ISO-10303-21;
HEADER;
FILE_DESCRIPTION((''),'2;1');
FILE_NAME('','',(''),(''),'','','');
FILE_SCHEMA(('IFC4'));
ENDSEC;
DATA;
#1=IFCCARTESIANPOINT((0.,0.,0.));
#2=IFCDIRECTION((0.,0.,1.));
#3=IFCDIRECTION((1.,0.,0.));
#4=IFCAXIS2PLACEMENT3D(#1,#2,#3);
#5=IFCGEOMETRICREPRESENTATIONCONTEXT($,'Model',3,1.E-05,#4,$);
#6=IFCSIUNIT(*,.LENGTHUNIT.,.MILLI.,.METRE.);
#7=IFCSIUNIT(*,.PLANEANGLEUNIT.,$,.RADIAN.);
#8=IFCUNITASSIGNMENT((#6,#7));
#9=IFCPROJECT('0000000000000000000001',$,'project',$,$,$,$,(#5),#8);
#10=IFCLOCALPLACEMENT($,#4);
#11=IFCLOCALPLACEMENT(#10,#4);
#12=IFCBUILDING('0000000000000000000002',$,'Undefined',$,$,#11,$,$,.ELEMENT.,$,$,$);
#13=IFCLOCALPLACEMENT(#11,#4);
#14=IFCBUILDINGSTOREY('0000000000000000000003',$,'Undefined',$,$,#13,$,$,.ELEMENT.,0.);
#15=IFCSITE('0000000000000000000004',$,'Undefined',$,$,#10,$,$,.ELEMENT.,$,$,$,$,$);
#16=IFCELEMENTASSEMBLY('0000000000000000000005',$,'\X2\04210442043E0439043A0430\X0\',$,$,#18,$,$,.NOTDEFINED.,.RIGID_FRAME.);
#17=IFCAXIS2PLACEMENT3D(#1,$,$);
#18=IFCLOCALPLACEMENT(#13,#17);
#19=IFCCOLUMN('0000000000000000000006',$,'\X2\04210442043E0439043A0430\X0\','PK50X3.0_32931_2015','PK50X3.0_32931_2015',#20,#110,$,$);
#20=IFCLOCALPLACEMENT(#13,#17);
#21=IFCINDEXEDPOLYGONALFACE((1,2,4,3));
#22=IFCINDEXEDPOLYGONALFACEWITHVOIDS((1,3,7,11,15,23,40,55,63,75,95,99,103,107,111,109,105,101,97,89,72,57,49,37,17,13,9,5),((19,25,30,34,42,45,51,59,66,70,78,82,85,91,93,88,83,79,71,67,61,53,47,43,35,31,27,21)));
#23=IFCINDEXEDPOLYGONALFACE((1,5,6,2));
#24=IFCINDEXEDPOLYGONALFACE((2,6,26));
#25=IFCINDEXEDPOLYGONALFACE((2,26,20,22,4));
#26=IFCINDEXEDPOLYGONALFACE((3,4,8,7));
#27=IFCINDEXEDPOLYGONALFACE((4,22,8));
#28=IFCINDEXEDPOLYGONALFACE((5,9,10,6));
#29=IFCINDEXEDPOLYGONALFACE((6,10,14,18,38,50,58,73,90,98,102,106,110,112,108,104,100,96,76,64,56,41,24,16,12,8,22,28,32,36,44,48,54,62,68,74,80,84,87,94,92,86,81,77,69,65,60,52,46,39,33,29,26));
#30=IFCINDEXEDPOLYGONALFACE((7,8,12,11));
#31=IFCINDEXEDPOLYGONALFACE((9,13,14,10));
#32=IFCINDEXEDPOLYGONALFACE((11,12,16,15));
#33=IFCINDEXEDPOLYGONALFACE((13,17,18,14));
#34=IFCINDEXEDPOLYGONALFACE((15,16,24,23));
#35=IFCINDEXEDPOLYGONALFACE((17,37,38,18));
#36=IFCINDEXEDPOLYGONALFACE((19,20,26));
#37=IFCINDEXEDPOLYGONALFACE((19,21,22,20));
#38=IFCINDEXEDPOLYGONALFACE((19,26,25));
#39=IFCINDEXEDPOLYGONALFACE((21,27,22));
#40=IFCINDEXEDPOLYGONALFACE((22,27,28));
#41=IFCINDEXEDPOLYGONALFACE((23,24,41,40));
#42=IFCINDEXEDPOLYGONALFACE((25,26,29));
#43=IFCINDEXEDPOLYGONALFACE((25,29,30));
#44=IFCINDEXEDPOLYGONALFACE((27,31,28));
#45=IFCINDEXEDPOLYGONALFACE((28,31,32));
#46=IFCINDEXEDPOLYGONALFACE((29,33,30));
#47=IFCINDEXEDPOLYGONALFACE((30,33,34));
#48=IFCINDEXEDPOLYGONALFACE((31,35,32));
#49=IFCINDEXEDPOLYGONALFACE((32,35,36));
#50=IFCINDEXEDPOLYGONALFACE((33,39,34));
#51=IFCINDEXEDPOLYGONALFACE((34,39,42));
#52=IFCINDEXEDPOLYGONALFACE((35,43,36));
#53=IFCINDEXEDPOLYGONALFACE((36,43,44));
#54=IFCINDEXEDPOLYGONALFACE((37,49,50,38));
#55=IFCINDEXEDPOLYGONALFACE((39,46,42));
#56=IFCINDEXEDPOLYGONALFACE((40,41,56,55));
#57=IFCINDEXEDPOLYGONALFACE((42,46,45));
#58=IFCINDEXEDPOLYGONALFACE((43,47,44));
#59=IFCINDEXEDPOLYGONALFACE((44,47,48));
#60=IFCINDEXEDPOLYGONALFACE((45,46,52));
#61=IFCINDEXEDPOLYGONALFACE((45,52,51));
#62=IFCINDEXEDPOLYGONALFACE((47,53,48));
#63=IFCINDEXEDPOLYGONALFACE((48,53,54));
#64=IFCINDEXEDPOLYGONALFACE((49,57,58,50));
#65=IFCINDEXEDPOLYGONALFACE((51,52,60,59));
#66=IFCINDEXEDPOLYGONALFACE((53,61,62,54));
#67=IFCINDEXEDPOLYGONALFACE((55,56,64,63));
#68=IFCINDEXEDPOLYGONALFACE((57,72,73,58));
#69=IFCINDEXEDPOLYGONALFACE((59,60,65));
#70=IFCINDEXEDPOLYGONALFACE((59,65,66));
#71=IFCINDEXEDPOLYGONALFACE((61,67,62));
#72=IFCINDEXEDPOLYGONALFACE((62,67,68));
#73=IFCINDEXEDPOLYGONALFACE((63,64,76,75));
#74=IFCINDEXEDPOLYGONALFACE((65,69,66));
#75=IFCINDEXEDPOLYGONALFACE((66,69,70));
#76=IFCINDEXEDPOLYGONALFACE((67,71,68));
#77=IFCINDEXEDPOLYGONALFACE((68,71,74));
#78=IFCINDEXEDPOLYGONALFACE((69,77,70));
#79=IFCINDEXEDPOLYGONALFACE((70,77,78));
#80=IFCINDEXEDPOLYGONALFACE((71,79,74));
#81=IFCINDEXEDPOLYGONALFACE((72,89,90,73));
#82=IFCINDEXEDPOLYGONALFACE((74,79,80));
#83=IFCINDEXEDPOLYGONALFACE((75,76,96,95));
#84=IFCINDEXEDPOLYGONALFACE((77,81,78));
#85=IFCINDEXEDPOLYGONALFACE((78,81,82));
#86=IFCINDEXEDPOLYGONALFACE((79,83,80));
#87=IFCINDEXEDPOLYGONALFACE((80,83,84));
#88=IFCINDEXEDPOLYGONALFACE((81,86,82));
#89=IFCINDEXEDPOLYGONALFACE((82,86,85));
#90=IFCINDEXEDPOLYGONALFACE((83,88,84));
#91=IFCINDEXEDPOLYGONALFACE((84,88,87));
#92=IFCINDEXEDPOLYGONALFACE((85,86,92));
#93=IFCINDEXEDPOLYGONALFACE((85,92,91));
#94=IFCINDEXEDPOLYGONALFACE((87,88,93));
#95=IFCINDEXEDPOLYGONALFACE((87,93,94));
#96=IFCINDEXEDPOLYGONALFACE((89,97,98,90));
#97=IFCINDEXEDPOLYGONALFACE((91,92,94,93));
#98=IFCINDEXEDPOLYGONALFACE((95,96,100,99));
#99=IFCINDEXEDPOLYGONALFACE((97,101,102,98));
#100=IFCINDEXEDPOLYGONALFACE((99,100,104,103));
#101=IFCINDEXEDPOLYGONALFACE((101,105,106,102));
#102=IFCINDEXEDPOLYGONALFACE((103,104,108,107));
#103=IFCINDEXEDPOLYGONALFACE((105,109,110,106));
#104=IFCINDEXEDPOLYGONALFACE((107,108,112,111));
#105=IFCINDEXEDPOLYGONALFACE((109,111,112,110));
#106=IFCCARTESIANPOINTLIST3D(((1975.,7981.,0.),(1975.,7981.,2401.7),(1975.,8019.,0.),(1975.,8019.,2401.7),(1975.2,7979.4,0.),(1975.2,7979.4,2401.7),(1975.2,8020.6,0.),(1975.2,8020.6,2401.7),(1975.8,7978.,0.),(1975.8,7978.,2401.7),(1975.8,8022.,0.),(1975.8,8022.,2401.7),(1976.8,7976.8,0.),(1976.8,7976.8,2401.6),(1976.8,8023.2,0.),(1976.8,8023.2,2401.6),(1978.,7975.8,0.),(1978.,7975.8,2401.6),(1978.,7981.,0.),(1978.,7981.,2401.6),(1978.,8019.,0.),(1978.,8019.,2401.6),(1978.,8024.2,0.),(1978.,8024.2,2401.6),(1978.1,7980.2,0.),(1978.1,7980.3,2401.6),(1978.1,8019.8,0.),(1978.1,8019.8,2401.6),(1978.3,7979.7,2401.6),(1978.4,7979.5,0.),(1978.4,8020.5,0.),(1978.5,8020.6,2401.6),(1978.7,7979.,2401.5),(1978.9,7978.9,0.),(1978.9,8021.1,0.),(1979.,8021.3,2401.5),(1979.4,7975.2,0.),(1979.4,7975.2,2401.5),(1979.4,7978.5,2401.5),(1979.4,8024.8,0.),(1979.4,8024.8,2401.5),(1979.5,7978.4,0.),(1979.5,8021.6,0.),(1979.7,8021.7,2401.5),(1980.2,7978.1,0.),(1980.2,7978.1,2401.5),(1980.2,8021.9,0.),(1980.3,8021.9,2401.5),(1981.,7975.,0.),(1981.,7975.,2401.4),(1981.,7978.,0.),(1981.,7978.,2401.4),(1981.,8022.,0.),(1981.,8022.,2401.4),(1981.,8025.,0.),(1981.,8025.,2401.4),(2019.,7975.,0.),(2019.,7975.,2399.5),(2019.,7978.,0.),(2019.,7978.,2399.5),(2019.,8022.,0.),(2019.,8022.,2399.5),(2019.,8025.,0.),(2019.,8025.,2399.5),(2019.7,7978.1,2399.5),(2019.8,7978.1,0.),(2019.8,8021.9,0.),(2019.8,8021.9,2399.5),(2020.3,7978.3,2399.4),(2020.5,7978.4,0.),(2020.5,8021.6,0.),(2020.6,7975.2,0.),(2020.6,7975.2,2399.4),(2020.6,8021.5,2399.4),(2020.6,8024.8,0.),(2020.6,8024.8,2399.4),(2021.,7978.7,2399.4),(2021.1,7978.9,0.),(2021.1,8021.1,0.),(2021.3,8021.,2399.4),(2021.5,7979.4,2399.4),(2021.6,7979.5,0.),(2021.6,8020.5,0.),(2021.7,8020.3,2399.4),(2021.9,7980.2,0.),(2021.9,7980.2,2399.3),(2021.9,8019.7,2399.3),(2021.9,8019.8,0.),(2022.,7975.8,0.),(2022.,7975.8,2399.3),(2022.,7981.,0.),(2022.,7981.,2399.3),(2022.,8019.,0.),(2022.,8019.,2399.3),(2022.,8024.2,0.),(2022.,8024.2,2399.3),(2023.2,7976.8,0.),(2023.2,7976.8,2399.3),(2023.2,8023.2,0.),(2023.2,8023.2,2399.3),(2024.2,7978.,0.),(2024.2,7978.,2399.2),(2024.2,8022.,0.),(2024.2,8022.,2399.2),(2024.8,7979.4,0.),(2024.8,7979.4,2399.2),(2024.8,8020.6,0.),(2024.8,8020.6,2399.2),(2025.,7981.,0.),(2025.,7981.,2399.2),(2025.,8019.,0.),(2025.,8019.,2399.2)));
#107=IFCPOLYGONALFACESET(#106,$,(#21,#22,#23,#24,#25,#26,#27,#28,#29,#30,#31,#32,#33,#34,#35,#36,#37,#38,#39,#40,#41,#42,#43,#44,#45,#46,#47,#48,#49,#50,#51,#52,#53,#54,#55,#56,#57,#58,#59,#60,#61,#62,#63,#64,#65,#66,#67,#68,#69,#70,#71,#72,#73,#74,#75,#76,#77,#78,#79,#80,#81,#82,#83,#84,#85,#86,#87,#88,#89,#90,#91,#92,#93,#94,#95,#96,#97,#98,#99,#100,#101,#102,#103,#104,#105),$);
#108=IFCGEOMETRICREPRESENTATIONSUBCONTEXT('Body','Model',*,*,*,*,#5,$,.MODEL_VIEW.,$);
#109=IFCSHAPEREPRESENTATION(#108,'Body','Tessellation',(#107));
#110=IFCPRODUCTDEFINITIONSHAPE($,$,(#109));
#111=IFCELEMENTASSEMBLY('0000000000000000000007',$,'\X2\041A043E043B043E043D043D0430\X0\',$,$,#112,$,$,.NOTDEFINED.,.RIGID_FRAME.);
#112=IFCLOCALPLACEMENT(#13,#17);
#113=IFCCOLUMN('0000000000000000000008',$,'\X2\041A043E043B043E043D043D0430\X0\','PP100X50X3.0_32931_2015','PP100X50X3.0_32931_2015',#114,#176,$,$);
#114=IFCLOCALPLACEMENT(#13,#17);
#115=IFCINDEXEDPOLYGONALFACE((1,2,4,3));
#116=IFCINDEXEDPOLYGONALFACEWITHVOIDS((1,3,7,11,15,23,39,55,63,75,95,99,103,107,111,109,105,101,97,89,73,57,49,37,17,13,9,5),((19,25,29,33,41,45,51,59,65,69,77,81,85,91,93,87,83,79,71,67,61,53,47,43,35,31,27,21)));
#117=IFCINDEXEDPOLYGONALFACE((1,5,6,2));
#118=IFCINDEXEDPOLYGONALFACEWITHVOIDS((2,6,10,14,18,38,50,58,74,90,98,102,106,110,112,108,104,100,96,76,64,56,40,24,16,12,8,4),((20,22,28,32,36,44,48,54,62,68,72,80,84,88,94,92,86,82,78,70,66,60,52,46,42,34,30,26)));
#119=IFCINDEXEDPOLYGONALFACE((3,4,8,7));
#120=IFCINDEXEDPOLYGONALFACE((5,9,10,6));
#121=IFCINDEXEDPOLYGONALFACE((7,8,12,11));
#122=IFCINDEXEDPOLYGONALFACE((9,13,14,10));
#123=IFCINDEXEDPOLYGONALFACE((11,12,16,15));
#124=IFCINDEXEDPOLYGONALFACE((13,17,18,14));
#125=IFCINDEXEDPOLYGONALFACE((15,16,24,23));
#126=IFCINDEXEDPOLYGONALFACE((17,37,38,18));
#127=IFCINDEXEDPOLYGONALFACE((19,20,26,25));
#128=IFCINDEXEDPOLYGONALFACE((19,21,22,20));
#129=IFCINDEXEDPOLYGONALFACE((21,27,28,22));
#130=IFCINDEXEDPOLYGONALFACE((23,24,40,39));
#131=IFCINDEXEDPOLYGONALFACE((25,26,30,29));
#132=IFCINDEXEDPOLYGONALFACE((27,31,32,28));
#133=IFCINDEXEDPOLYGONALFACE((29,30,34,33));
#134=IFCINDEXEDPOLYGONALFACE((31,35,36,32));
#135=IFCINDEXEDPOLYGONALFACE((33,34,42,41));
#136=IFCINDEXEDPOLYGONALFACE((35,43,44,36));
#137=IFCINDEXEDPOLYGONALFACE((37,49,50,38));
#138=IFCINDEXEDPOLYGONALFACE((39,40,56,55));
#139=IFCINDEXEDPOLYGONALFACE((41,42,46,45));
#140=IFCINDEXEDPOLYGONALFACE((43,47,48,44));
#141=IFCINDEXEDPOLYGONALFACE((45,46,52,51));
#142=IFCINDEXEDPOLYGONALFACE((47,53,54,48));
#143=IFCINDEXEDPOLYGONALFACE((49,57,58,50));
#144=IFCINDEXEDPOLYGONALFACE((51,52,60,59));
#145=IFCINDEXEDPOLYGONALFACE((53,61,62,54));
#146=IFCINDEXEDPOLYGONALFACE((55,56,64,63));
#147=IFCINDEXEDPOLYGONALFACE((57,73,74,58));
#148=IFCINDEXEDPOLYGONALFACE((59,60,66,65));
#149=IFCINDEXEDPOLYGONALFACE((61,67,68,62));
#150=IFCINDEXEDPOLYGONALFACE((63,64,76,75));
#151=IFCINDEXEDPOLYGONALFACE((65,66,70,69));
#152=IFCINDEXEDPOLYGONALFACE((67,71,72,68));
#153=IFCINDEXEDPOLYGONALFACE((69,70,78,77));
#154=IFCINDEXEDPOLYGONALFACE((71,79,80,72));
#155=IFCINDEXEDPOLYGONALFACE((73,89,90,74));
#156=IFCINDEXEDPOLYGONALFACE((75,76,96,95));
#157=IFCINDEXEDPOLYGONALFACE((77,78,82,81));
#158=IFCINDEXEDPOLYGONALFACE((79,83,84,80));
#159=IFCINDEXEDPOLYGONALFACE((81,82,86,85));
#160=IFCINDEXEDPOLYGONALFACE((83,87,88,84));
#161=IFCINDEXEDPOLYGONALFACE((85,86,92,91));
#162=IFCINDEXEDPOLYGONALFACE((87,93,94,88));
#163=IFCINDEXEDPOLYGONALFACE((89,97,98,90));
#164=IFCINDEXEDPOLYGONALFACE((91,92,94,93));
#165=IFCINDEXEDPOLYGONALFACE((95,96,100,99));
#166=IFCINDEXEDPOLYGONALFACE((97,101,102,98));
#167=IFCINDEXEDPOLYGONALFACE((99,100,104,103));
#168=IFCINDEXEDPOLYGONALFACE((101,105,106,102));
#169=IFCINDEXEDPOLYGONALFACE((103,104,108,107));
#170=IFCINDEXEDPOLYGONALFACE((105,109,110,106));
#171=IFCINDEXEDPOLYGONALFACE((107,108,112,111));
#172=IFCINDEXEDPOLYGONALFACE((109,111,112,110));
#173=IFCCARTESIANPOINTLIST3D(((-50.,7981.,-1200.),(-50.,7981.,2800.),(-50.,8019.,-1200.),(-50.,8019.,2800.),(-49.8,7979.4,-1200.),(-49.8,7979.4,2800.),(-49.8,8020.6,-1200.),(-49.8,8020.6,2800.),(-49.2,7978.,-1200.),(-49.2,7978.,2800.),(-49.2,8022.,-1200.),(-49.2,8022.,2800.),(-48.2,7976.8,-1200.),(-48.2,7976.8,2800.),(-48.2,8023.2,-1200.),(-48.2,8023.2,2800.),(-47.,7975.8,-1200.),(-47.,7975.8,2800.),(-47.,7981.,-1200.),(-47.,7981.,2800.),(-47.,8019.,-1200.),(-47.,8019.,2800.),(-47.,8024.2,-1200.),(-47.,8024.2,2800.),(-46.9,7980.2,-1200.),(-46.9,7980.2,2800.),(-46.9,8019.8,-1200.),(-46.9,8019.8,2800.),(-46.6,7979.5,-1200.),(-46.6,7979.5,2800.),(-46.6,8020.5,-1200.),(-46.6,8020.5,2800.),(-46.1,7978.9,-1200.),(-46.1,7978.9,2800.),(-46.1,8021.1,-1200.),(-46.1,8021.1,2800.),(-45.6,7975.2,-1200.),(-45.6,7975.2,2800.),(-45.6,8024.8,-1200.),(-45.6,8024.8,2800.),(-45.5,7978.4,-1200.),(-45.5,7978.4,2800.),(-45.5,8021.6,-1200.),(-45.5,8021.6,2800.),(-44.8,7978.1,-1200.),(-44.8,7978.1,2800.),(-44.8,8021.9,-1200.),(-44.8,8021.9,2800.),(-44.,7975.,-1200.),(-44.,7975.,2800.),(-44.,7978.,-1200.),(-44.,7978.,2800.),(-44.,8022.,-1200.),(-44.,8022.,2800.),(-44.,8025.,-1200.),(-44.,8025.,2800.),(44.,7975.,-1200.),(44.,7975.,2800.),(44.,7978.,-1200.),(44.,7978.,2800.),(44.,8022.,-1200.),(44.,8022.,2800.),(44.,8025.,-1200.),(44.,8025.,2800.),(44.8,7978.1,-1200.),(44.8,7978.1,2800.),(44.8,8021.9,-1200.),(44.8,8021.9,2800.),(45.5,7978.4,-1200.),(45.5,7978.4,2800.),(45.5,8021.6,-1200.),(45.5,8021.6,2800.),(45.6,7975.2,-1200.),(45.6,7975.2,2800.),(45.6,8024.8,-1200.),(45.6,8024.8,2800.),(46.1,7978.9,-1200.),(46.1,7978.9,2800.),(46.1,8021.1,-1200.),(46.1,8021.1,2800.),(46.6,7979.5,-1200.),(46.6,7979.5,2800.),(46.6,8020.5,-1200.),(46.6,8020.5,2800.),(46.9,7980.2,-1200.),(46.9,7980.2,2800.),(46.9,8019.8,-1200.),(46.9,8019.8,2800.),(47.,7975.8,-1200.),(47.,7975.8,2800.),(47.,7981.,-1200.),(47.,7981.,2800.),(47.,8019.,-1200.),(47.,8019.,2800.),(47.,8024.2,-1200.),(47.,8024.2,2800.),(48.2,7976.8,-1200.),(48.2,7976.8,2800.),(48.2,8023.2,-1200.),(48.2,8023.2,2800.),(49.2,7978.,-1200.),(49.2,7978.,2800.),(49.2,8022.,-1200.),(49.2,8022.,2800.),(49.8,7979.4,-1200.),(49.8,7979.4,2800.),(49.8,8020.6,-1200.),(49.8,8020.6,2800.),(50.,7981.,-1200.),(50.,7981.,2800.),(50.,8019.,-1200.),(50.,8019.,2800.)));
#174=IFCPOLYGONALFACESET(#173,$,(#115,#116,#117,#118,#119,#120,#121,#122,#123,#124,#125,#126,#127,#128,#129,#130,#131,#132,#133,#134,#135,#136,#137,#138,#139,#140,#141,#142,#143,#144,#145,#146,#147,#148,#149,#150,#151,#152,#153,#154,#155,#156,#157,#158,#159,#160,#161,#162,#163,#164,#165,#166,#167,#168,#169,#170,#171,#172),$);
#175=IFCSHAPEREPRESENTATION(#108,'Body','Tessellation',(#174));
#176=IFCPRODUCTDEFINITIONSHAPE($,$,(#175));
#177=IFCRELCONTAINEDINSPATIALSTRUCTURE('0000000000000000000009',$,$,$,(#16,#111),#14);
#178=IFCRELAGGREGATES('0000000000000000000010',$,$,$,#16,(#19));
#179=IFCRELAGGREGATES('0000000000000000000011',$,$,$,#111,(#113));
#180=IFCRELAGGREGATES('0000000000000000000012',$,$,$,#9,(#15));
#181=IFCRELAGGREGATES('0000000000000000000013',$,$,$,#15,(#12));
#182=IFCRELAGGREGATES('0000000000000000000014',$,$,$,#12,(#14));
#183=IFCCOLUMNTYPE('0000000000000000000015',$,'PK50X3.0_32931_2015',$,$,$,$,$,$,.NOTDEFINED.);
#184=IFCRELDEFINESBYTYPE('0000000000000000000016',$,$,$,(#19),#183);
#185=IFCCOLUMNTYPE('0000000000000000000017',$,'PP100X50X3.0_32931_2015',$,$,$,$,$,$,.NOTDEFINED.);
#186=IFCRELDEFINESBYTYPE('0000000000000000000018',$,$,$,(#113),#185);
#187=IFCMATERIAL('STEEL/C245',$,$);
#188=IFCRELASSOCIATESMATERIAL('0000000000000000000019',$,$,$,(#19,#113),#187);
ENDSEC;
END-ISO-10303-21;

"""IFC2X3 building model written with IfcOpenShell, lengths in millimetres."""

from ifc_helpers import new_model, si_unit, frame, origin_with_axes, origin_2d_with_axis, place, context, subcontext, project, spatial, hollow_rectangle, extrude, clip, halfspace, material, type_object, element, aggregate, save


model = new_model("IFC2X3")

# Units and contexts
model_context = context("Model", 3, precision=1e-05, world=origin_with_axes())
body_context = subcontext(model_context, "Body", "Model", "MODEL_VIEW")
ifc_project = project(units=[si_unit("LENGTHUNIT", "METRE", prefix="MILLI"), si_unit("PLANEANGLEUNIT", "RADIAN")], contexts=[model_context])

# Site, building, storey
site_placement = place(None, origin_with_axes())
site = spatial("IfcSite", under=ifc_project, at=site_placement, Name="Undefined", CompositionType="ELEMENT")
building_placement = place(site_placement, origin_with_axes())
building = spatial("IfcBuilding", under=site, at=building_placement, Name="Undefined", CompositionType="ELEMENT")
storey_placement = place(building_placement, origin_with_axes())
storey = spatial("IfcBuildingStorey", under=building, at=storey_placement, Name="Undefined", CompositionType="ELEMENT", Elevation=0.0)

# Element assemblies, columns
ifc_material_1 = material(Name="STEEL/C245")
column_type_1 = type_object("IfcColumnType", Name="PK50X3.0_32931_2015", PredefinedType="NOTDEFINED")
assembly_1_placement = place(storey_placement, origin_with_axes())
assembly_1 = element("IfcElementAssembly", 1, at=assembly_1_placement, inside=storey, Name="Стойка", AssemblyPlace="NOTDEFINED", PredefinedType="RIGID_FRAME")
column_1_placement = place(assembly_1_placement, frame((2000.0, 8000.0, 0.0), z_axis=(0.0, 0.0, 1.0), x_axis=(0.0, 1.0, 0.0)))
column_1 = element("IfcColumn", 2, at=column_1_placement, type_object=column_type_1, material=ifc_material_1, Name="Стойка", Description="PK50X3.0_32931_2015", ObjectType="PK50X3.0_32931_2015", context=body_context, shape_type="Clipping", body=[
    clip(extrude(hollow_rectangle(XDim=50.0, YDim=50.0, WallThickness=3.0, InnerFilletRadius=3.0, OuterFilletRadius=6.0, at=origin_2d_with_axis()), frame((0.0, 0.0, 2401.7), z_axis=(0.0, 0.0, -1.0), x_axis=(0.0, 1.0, 0.0)), (0.0, 0.0, 1.0), 2401.7), halfspace(frame((0.0, -2147.1, 2291.3), z_axis=(0.0, 0.050782, -0.99871), x_axis=(-1.0, 0.0, 0.0)), True)),
])
aggregate(assembly_1, [column_1])
assembly_2_placement = place(storey_placement, origin_with_axes())
assembly_2 = element("IfcElementAssembly", 3, at=assembly_2_placement, inside=storey, Name="Колонна", AssemblyPlace="NOTDEFINED", PredefinedType="RIGID_FRAME")
column_type_2 = type_object("IfcColumnType", Name="PP100X50X3.0_32931_2015", PredefinedType="NOTDEFINED")
column_2_placement = place(assembly_2_placement, frame((0.0, 8000.0, -1200.0), z_axis=(0.0, 0.0, 1.0), x_axis=(-1.0, 0.0, 0.0)))
column_2 = element("IfcColumn", 4, at=column_2_placement, type_object=column_type_2, material=ifc_material_1, Name="Колонна", Description="PP100X50X3.0_32931_2015", ObjectType="PP100X50X3.0_32931_2015", context=body_context, shape_type="SweptSolid", body=[
    extrude(hollow_rectangle(XDim=50.0, YDim=100.0, WallThickness=3.0, InnerFilletRadius=3.0, OuterFilletRadius=6.0, at=origin_2d_with_axis()), frame((0.0, 0.0, 4000.0), z_axis=(0.0, 0.0, -1.0), x_axis=(0.0, 1.0, 0.0)), (0.0, 0.0, 1.0), 4000.0),
])
aggregate(assembly_2, [column_2])

save(model, "model.ifc")
